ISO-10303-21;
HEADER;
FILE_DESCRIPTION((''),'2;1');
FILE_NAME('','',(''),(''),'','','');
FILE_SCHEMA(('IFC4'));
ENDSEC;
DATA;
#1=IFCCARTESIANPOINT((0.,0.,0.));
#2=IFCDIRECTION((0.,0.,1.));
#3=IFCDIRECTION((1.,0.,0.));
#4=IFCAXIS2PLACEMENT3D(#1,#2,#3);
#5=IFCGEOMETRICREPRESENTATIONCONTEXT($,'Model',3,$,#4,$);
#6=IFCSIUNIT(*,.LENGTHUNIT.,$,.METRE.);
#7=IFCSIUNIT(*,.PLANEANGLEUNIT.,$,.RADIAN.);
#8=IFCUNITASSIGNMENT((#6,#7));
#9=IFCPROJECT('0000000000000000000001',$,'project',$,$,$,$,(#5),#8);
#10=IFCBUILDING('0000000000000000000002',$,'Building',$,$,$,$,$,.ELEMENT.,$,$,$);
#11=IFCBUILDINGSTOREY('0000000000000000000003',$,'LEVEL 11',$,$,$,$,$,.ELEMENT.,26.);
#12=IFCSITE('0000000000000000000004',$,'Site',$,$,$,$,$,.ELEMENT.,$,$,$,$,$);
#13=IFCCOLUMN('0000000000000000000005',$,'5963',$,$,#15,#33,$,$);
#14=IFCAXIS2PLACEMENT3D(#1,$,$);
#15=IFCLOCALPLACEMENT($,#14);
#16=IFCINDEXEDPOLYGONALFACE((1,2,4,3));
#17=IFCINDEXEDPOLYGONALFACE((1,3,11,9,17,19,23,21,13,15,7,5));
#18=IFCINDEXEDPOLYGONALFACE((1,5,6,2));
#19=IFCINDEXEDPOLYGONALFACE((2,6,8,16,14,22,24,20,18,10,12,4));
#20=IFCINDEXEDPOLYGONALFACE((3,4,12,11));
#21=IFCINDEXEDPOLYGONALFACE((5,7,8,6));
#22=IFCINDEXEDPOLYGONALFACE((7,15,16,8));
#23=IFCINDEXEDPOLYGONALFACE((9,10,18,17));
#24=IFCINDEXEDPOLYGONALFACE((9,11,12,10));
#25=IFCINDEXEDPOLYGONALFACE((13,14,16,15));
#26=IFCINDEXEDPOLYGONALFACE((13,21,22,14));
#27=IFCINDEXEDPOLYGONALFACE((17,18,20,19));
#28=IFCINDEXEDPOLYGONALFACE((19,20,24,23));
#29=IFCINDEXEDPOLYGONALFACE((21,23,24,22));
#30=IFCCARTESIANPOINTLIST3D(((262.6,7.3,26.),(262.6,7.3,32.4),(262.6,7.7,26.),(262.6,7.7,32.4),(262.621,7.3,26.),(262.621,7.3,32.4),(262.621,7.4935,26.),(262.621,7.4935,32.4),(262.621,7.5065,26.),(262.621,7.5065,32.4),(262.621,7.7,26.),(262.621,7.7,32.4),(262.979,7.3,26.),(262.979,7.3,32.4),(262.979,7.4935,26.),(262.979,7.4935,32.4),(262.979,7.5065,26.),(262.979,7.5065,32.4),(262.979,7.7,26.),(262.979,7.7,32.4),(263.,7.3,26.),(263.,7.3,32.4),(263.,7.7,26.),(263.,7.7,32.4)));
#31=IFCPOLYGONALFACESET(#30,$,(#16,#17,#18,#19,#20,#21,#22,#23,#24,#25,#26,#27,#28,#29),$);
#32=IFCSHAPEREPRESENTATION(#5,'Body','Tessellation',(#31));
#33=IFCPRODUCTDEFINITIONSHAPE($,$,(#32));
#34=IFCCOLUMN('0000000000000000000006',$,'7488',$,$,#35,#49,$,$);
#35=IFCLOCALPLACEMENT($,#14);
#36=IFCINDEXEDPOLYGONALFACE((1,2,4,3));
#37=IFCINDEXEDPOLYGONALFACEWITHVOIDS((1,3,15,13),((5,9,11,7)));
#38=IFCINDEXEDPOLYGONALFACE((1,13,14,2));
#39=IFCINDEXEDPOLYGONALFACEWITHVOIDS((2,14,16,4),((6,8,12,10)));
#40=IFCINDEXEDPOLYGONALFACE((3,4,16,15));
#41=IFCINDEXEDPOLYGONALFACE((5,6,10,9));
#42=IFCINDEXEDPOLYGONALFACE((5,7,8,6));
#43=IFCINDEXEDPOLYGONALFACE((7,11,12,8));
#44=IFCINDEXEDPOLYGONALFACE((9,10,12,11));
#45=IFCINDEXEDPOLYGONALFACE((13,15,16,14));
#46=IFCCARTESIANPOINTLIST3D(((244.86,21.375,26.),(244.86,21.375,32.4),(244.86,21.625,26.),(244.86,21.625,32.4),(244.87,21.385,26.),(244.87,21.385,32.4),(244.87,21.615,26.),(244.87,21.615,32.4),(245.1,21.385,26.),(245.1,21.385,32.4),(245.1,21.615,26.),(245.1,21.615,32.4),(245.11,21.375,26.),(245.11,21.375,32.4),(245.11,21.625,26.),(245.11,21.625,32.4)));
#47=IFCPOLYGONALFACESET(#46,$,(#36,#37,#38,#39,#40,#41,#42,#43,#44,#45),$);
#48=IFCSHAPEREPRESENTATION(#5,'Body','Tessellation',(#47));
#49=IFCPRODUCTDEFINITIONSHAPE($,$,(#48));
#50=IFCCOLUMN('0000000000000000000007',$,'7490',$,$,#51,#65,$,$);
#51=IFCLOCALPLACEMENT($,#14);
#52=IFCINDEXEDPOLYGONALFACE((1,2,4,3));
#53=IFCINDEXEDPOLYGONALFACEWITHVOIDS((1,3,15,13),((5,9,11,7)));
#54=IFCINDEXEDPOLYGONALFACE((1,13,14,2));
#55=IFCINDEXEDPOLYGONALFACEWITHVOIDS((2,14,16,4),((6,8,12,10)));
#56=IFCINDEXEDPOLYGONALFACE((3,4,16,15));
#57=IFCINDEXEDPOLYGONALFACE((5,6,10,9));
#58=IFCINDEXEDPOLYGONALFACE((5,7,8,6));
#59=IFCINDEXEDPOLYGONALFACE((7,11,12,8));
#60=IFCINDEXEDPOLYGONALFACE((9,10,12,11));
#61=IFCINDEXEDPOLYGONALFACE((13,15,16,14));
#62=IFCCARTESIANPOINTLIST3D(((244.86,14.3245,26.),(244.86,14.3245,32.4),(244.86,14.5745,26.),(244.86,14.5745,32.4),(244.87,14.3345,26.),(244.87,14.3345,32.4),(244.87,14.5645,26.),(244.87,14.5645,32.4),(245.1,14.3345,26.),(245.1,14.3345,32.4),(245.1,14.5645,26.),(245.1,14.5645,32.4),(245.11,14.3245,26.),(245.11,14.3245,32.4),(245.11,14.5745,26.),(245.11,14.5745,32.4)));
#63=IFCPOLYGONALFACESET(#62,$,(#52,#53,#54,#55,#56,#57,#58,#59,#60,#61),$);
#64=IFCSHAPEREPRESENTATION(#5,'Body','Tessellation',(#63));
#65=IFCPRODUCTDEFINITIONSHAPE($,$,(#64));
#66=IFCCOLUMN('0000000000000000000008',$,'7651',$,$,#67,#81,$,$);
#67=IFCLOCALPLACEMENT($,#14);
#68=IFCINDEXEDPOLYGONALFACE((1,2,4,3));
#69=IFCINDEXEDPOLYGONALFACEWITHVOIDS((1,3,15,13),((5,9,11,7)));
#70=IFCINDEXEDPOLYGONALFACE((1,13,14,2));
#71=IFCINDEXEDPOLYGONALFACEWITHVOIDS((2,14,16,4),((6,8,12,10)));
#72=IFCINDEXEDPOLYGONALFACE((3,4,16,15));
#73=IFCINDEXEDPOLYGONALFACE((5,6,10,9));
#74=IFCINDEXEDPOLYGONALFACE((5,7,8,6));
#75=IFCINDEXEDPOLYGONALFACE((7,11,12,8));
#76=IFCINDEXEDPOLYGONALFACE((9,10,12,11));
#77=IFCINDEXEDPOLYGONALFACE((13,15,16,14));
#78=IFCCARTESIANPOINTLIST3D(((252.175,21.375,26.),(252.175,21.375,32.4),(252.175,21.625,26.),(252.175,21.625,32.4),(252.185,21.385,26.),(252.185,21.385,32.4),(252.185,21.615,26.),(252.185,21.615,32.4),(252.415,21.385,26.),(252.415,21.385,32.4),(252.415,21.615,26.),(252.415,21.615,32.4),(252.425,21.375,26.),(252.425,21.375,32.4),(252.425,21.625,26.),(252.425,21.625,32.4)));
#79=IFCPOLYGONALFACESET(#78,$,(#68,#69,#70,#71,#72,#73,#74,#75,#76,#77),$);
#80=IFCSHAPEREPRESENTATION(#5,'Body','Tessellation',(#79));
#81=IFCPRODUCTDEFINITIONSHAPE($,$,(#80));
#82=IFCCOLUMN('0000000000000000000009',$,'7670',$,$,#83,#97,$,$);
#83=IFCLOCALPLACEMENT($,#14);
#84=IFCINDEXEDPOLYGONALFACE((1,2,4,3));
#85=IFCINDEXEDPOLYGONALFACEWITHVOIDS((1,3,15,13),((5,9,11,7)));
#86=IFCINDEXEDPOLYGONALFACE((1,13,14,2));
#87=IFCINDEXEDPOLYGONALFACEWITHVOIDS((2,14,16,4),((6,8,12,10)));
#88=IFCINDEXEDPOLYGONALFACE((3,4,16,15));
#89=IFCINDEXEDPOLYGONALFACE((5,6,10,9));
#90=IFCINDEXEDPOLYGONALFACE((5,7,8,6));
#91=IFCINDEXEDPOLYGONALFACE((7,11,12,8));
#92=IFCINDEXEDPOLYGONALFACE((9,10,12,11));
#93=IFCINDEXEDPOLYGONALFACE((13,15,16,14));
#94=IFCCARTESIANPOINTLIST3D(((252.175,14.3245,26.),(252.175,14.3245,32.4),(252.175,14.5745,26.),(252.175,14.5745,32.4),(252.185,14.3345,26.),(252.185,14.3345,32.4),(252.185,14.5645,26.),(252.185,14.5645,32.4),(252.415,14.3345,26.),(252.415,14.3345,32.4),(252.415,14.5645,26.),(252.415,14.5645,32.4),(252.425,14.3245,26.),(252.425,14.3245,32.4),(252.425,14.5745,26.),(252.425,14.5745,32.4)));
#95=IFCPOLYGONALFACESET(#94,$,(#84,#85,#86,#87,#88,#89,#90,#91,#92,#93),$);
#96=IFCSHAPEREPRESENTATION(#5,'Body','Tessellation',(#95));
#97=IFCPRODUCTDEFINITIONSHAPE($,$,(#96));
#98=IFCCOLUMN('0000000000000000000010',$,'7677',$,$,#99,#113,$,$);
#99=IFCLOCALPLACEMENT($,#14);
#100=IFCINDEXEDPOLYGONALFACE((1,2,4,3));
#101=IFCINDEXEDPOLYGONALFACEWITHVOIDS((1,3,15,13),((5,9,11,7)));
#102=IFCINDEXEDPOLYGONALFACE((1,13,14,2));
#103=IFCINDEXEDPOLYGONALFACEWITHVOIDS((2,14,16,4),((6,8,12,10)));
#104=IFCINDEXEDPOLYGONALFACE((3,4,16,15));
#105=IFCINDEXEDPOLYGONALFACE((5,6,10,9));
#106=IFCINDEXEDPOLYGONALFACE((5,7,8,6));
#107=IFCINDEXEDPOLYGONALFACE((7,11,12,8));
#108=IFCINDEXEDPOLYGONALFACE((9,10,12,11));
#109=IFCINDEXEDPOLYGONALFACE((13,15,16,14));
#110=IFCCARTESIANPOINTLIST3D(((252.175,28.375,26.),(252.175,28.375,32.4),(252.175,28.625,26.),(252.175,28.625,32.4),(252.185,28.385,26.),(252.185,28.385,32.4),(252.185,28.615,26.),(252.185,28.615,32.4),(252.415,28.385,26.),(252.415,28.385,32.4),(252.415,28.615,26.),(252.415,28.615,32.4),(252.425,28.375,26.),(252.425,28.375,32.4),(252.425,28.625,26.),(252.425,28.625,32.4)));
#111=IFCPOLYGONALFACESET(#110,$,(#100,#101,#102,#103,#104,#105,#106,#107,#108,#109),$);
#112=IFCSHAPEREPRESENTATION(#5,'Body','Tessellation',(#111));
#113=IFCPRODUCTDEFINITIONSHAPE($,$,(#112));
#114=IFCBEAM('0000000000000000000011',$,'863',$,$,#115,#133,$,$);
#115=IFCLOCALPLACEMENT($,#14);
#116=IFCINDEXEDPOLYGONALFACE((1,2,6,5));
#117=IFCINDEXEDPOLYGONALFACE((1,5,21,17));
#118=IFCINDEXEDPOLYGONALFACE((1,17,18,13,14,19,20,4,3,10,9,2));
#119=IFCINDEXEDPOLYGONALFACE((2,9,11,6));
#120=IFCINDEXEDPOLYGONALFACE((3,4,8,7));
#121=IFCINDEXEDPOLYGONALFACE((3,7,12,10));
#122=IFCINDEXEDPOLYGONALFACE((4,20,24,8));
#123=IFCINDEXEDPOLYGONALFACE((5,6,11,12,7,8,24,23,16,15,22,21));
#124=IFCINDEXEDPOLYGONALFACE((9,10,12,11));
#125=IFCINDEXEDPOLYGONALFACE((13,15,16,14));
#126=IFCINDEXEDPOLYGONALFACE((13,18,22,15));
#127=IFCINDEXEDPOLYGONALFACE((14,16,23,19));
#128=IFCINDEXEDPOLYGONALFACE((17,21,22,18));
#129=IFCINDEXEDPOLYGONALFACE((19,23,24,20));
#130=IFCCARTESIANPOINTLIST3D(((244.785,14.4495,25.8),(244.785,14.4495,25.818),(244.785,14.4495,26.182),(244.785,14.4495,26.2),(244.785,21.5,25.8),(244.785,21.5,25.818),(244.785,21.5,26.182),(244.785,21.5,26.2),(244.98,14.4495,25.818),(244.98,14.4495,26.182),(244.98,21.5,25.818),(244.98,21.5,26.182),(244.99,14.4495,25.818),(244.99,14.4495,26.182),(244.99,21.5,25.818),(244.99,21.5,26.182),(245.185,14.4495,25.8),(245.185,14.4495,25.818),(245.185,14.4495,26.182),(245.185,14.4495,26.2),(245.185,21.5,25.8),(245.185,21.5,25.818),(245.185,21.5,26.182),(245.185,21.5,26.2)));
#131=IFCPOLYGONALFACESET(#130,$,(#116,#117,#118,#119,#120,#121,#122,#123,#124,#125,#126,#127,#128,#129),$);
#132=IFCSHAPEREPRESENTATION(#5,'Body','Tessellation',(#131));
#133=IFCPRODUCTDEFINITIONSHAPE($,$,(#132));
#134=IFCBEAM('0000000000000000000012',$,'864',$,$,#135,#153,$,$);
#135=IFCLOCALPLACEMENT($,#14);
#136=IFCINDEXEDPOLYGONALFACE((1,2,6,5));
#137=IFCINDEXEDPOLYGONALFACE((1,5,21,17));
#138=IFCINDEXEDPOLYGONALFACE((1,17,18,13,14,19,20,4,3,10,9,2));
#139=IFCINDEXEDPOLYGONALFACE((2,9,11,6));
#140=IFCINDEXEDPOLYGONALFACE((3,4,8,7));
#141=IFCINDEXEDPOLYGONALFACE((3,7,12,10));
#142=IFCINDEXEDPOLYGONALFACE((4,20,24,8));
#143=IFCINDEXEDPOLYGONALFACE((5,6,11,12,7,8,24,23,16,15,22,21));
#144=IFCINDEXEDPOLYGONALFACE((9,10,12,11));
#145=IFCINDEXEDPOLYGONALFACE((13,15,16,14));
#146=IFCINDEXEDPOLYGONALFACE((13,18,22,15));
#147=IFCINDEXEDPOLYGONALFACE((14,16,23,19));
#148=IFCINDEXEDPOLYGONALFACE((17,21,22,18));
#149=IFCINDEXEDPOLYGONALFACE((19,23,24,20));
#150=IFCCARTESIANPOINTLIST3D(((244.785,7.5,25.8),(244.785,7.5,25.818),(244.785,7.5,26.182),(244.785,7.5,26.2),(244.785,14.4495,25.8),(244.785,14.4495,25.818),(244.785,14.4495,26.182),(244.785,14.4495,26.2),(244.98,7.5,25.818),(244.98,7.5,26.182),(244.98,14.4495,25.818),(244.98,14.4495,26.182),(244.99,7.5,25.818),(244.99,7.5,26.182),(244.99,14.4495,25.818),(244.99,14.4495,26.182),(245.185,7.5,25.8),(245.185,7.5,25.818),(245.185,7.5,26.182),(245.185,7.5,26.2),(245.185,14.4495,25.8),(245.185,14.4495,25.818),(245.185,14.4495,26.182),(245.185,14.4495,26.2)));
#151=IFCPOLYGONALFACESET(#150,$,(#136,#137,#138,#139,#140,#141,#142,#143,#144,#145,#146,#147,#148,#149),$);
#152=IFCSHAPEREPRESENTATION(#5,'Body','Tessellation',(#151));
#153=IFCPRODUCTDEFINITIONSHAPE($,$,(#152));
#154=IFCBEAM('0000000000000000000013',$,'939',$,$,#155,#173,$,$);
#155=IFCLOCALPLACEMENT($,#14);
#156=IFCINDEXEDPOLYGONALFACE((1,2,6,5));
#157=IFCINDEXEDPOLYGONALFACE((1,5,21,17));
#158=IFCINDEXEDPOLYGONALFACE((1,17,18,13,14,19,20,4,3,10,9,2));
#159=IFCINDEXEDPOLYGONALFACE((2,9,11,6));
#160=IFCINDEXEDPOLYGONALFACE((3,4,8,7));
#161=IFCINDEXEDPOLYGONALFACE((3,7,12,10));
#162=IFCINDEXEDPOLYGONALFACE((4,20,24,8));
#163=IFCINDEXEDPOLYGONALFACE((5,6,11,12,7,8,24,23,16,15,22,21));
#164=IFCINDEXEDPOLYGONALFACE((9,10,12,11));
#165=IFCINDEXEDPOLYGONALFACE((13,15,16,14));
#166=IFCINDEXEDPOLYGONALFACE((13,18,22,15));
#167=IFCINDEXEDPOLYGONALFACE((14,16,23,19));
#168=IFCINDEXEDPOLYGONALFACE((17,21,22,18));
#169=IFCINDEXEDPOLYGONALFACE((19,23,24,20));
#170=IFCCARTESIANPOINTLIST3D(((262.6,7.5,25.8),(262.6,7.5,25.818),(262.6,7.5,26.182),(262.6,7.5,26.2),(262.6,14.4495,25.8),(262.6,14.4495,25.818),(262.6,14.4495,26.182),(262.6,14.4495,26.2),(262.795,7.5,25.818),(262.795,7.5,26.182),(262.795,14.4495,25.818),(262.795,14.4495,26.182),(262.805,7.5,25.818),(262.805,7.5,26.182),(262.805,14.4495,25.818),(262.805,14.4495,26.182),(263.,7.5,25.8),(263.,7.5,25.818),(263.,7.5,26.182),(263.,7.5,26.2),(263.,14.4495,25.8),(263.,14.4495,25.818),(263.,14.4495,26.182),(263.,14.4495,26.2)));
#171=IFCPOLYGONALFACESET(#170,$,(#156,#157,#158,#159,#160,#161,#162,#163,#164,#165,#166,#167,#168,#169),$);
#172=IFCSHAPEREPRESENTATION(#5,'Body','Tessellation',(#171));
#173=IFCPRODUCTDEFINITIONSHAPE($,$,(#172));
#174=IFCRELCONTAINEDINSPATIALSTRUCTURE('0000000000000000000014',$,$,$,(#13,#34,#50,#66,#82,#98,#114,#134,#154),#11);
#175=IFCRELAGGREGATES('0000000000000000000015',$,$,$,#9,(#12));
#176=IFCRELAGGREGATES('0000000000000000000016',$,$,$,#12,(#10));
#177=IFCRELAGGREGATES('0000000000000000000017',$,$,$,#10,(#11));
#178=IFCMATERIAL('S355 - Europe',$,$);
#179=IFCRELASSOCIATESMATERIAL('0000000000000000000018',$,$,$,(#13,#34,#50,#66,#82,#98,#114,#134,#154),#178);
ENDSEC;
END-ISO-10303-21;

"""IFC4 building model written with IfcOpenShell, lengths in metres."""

from ifc_helpers import new_model, si_unit, frame, origin_with_axes, origin_2d_with_axis, place, context, project, spatial, hollow_rectangle, i_section, extrude, material, material_profile, profile_set, profile_usage, element, save


model = new_model("IFC4")

# Units and contexts
model_context = context("Model", 3, world=origin_with_axes())
ifc_project = project(units=[si_unit("LENGTHUNIT", "METRE"), si_unit("PLANEANGLEUNIT", "RADIAN")], contexts=[model_context])

# Site, building, storey
site = spatial("IfcSite", under=ifc_project, Name="Site", CompositionType="ELEMENT")
building = spatial("IfcBuilding", under=site, Name="Building", CompositionType="ELEMENT")
storey = spatial("IfcBuildingStorey", under=building, Name="LEVEL 11", CompositionType="ELEMENT", Elevation=26.0)

# Columns
ifc_material = material(Name="S355 - Europe")
ifc_material_profile_1 = material_profile(ifc_material, i_section(OverallWidth=0.4, OverallDepth=0.4, WebThickness=0.013, FlangeThickness=0.021, at=origin_2d_with_axis()))
ifc_profile_set_1 = profile_set([ifc_material_profile_1])
ifc_profile_usage_1 = profile_usage(ifc_profile_set_1, cardinal=10)
column_1_placement = place(None, frame((262.8, 7.5, 26.0), z_axis=(0.0, 0.0, 1.0), x_axis=(0.0, -1.0, 0.0)))
element("IfcColumn", 1, at=column_1_placement, inside=storey, material=ifc_profile_usage_1, Name="5963", context=model_context, shape_type="SweptSolid", body=[
    extrude(i_section(OverallWidth=0.4, OverallDepth=0.4, WebThickness=0.013, FlangeThickness=0.021, at=origin_2d_with_axis()), origin_with_axes(), (0.0, 0.0, 1.0), 6.4),
])
ifc_material_profile_2 = material_profile(ifc_material, hollow_rectangle(XDim=0.25, YDim=0.25, WallThickness=0.01, at=origin_2d_with_axis()))
ifc_profile_set_2 = profile_set([ifc_material_profile_2])
ifc_profile_usage_2 = profile_usage(ifc_profile_set_2, cardinal=10)
column_2_placement = place(None, frame((244.985, 21.5, 26.0), z_axis=(0.0, 0.0, 1.0), x_axis=(0.0, -1.0, 0.0)))
element("IfcColumn", 2, at=column_2_placement, inside=storey, material=ifc_profile_usage_2, Name="7488", context=model_context, shape_type="SweptSolid", body=[
    extrude(hollow_rectangle(XDim=0.25, YDim=0.25, WallThickness=0.01, at=origin_2d_with_axis()), origin_with_axes(), (0.0, 0.0, 1.0), 6.4),
])
ifc_material_profile_3 = material_profile(ifc_material, hollow_rectangle(XDim=0.25, YDim=0.25, WallThickness=0.01, at=origin_2d_with_axis()))
ifc_profile_set_3 = profile_set([ifc_material_profile_3])
ifc_profile_usage_3 = profile_usage(ifc_profile_set_3, cardinal=10)
column_3_placement = place(None, frame((244.985, 14.4495, 26.0), z_axis=(0.0, 0.0, 1.0), x_axis=(0.0, -1.0, 0.0)))
element("IfcColumn", 3, at=column_3_placement, inside=storey, material=ifc_profile_usage_3, Name="7490", context=model_context, shape_type="SweptSolid", body=[
    extrude(hollow_rectangle(XDim=0.25, YDim=0.25, WallThickness=0.01, at=origin_2d_with_axis()), origin_with_axes(), (0.0, 0.0, 1.0), 6.4),
])
ifc_material_profile_4 = material_profile(ifc_material, hollow_rectangle(XDim=0.25, YDim=0.25, WallThickness=0.01, at=origin_2d_with_axis()))
ifc_profile_set_4 = profile_set([ifc_material_profile_4])
ifc_profile_usage_4 = profile_usage(ifc_profile_set_4, cardinal=10)
column_4_placement = place(None, frame((252.3, 21.5, 26.0), z_axis=(0.0, 0.0, 1.0), x_axis=(0.0, -1.0, 0.0)))
element("IfcColumn", 4, at=column_4_placement, inside=storey, material=ifc_profile_usage_4, Name="7651", context=model_context, shape_type="SweptSolid", body=[
    extrude(hollow_rectangle(XDim=0.25, YDim=0.25, WallThickness=0.01, at=origin_2d_with_axis()), origin_with_axes(), (0.0, 0.0, 1.0), 6.4),
])
ifc_material_profile_5 = material_profile(ifc_material, hollow_rectangle(XDim=0.25, YDim=0.25, WallThickness=0.01, at=origin_2d_with_axis()))
ifc_profile_set_5 = profile_set([ifc_material_profile_5])
ifc_profile_usage_5 = profile_usage(ifc_profile_set_5, cardinal=10)
column_5_placement = place(None, frame((252.3, 14.4495, 26.0), z_axis=(0.0, 0.0, 1.0), x_axis=(0.0, -1.0, 0.0)))
element("IfcColumn", 5, at=column_5_placement, inside=storey, material=ifc_profile_usage_5, Name="7670", context=model_context, shape_type="SweptSolid", body=[
    extrude(hollow_rectangle(XDim=0.25, YDim=0.25, WallThickness=0.01, at=origin_2d_with_axis()), origin_with_axes(), (0.0, 0.0, 1.0), 6.4),
])
ifc_material_profile_6 = material_profile(ifc_material, hollow_rectangle(XDim=0.25, YDim=0.25, WallThickness=0.01, at=origin_2d_with_axis()))
ifc_profile_set_6 = profile_set([ifc_material_profile_6])
ifc_profile_usage_6 = profile_usage(ifc_profile_set_6, cardinal=10)
column_6_placement = place(None, frame((252.3, 28.5, 26.0), z_axis=(0.0, 0.0, 1.0), x_axis=(0.0, -1.0, 0.0)))
element("IfcColumn", 6, at=column_6_placement, inside=storey, material=ifc_profile_usage_6, Name="7677", context=model_context, shape_type="SweptSolid", body=[
    extrude(hollow_rectangle(XDim=0.25, YDim=0.25, WallThickness=0.01, at=origin_2d_with_axis()), origin_with_axes(), (0.0, 0.0, 1.0), 6.4),
])

# Beams
ifc_material_profile_7 = material_profile(ifc_material, i_section(OverallWidth=0.4, OverallDepth=0.4, WebThickness=0.01, FlangeThickness=0.018, at=origin_2d_with_axis()))
ifc_profile_set_7 = profile_set([ifc_material_profile_7])
ifc_profile_usage_7 = profile_usage(ifc_profile_set_7, cardinal=10)
beam_1_placement = place(None, frame((244.985, 21.5, 26.0), z_axis=(0.0, -1.0, 0.0), x_axis=(1.0, 0.0, 0.0)))
element("IfcBeam", 7, at=beam_1_placement, inside=storey, material=ifc_profile_usage_7, Name="863", context=model_context, shape_type="SweptSolid", body=[
    extrude(i_section(OverallWidth=0.4, OverallDepth=0.4, WebThickness=0.01, FlangeThickness=0.018, at=origin_2d_with_axis()), origin_with_axes(), (0.0, 0.0, 1.0), 7.0505),
])
ifc_material_profile_8 = material_profile(ifc_material, i_section(OverallWidth=0.4, OverallDepth=0.4, WebThickness=0.01, FlangeThickness=0.018, at=origin_2d_with_axis()))
ifc_profile_set_8 = profile_set([ifc_material_profile_8])
ifc_profile_usage_8 = profile_usage(ifc_profile_set_8, cardinal=10)
beam_2_placement = place(None, frame((244.985, 14.4495, 26.0), z_axis=(0.0, -1.0, 0.0), x_axis=(1.0, 0.0, 0.0)))
element("IfcBeam", 8, at=beam_2_placement, inside=storey, material=ifc_profile_usage_8, Name="864", context=model_context, shape_type="SweptSolid", body=[
    extrude(i_section(OverallWidth=0.4, OverallDepth=0.4, WebThickness=0.01, FlangeThickness=0.018, at=origin_2d_with_axis()), origin_with_axes(), (0.0, 0.0, 1.0), 6.9495),
])
ifc_material_profile_9 = material_profile(ifc_material, i_section(OverallWidth=0.4, OverallDepth=0.4, WebThickness=0.01, FlangeThickness=0.018, at=origin_2d_with_axis()))
ifc_profile_set_9 = profile_set([ifc_material_profile_9])
ifc_profile_usage_9 = profile_usage(ifc_profile_set_9, cardinal=10)
beam_3_placement = place(None, frame((262.8, 7.5, 26.0), z_axis=(0.0, 1.0, 0.0), x_axis=(-1.0, 0.0, 0.0)))
element("IfcBeam", 9, at=beam_3_placement, inside=storey, material=ifc_profile_usage_9, Name="939", context=model_context, shape_type="SweptSolid", body=[
    extrude(i_section(OverallWidth=0.4, OverallDepth=0.4, WebThickness=0.01, FlangeThickness=0.018, at=origin_2d_with_axis()), origin_with_axes(), (0.0, 0.0, 1.0), 6.9495),
])

save(model, "model.ifc")
